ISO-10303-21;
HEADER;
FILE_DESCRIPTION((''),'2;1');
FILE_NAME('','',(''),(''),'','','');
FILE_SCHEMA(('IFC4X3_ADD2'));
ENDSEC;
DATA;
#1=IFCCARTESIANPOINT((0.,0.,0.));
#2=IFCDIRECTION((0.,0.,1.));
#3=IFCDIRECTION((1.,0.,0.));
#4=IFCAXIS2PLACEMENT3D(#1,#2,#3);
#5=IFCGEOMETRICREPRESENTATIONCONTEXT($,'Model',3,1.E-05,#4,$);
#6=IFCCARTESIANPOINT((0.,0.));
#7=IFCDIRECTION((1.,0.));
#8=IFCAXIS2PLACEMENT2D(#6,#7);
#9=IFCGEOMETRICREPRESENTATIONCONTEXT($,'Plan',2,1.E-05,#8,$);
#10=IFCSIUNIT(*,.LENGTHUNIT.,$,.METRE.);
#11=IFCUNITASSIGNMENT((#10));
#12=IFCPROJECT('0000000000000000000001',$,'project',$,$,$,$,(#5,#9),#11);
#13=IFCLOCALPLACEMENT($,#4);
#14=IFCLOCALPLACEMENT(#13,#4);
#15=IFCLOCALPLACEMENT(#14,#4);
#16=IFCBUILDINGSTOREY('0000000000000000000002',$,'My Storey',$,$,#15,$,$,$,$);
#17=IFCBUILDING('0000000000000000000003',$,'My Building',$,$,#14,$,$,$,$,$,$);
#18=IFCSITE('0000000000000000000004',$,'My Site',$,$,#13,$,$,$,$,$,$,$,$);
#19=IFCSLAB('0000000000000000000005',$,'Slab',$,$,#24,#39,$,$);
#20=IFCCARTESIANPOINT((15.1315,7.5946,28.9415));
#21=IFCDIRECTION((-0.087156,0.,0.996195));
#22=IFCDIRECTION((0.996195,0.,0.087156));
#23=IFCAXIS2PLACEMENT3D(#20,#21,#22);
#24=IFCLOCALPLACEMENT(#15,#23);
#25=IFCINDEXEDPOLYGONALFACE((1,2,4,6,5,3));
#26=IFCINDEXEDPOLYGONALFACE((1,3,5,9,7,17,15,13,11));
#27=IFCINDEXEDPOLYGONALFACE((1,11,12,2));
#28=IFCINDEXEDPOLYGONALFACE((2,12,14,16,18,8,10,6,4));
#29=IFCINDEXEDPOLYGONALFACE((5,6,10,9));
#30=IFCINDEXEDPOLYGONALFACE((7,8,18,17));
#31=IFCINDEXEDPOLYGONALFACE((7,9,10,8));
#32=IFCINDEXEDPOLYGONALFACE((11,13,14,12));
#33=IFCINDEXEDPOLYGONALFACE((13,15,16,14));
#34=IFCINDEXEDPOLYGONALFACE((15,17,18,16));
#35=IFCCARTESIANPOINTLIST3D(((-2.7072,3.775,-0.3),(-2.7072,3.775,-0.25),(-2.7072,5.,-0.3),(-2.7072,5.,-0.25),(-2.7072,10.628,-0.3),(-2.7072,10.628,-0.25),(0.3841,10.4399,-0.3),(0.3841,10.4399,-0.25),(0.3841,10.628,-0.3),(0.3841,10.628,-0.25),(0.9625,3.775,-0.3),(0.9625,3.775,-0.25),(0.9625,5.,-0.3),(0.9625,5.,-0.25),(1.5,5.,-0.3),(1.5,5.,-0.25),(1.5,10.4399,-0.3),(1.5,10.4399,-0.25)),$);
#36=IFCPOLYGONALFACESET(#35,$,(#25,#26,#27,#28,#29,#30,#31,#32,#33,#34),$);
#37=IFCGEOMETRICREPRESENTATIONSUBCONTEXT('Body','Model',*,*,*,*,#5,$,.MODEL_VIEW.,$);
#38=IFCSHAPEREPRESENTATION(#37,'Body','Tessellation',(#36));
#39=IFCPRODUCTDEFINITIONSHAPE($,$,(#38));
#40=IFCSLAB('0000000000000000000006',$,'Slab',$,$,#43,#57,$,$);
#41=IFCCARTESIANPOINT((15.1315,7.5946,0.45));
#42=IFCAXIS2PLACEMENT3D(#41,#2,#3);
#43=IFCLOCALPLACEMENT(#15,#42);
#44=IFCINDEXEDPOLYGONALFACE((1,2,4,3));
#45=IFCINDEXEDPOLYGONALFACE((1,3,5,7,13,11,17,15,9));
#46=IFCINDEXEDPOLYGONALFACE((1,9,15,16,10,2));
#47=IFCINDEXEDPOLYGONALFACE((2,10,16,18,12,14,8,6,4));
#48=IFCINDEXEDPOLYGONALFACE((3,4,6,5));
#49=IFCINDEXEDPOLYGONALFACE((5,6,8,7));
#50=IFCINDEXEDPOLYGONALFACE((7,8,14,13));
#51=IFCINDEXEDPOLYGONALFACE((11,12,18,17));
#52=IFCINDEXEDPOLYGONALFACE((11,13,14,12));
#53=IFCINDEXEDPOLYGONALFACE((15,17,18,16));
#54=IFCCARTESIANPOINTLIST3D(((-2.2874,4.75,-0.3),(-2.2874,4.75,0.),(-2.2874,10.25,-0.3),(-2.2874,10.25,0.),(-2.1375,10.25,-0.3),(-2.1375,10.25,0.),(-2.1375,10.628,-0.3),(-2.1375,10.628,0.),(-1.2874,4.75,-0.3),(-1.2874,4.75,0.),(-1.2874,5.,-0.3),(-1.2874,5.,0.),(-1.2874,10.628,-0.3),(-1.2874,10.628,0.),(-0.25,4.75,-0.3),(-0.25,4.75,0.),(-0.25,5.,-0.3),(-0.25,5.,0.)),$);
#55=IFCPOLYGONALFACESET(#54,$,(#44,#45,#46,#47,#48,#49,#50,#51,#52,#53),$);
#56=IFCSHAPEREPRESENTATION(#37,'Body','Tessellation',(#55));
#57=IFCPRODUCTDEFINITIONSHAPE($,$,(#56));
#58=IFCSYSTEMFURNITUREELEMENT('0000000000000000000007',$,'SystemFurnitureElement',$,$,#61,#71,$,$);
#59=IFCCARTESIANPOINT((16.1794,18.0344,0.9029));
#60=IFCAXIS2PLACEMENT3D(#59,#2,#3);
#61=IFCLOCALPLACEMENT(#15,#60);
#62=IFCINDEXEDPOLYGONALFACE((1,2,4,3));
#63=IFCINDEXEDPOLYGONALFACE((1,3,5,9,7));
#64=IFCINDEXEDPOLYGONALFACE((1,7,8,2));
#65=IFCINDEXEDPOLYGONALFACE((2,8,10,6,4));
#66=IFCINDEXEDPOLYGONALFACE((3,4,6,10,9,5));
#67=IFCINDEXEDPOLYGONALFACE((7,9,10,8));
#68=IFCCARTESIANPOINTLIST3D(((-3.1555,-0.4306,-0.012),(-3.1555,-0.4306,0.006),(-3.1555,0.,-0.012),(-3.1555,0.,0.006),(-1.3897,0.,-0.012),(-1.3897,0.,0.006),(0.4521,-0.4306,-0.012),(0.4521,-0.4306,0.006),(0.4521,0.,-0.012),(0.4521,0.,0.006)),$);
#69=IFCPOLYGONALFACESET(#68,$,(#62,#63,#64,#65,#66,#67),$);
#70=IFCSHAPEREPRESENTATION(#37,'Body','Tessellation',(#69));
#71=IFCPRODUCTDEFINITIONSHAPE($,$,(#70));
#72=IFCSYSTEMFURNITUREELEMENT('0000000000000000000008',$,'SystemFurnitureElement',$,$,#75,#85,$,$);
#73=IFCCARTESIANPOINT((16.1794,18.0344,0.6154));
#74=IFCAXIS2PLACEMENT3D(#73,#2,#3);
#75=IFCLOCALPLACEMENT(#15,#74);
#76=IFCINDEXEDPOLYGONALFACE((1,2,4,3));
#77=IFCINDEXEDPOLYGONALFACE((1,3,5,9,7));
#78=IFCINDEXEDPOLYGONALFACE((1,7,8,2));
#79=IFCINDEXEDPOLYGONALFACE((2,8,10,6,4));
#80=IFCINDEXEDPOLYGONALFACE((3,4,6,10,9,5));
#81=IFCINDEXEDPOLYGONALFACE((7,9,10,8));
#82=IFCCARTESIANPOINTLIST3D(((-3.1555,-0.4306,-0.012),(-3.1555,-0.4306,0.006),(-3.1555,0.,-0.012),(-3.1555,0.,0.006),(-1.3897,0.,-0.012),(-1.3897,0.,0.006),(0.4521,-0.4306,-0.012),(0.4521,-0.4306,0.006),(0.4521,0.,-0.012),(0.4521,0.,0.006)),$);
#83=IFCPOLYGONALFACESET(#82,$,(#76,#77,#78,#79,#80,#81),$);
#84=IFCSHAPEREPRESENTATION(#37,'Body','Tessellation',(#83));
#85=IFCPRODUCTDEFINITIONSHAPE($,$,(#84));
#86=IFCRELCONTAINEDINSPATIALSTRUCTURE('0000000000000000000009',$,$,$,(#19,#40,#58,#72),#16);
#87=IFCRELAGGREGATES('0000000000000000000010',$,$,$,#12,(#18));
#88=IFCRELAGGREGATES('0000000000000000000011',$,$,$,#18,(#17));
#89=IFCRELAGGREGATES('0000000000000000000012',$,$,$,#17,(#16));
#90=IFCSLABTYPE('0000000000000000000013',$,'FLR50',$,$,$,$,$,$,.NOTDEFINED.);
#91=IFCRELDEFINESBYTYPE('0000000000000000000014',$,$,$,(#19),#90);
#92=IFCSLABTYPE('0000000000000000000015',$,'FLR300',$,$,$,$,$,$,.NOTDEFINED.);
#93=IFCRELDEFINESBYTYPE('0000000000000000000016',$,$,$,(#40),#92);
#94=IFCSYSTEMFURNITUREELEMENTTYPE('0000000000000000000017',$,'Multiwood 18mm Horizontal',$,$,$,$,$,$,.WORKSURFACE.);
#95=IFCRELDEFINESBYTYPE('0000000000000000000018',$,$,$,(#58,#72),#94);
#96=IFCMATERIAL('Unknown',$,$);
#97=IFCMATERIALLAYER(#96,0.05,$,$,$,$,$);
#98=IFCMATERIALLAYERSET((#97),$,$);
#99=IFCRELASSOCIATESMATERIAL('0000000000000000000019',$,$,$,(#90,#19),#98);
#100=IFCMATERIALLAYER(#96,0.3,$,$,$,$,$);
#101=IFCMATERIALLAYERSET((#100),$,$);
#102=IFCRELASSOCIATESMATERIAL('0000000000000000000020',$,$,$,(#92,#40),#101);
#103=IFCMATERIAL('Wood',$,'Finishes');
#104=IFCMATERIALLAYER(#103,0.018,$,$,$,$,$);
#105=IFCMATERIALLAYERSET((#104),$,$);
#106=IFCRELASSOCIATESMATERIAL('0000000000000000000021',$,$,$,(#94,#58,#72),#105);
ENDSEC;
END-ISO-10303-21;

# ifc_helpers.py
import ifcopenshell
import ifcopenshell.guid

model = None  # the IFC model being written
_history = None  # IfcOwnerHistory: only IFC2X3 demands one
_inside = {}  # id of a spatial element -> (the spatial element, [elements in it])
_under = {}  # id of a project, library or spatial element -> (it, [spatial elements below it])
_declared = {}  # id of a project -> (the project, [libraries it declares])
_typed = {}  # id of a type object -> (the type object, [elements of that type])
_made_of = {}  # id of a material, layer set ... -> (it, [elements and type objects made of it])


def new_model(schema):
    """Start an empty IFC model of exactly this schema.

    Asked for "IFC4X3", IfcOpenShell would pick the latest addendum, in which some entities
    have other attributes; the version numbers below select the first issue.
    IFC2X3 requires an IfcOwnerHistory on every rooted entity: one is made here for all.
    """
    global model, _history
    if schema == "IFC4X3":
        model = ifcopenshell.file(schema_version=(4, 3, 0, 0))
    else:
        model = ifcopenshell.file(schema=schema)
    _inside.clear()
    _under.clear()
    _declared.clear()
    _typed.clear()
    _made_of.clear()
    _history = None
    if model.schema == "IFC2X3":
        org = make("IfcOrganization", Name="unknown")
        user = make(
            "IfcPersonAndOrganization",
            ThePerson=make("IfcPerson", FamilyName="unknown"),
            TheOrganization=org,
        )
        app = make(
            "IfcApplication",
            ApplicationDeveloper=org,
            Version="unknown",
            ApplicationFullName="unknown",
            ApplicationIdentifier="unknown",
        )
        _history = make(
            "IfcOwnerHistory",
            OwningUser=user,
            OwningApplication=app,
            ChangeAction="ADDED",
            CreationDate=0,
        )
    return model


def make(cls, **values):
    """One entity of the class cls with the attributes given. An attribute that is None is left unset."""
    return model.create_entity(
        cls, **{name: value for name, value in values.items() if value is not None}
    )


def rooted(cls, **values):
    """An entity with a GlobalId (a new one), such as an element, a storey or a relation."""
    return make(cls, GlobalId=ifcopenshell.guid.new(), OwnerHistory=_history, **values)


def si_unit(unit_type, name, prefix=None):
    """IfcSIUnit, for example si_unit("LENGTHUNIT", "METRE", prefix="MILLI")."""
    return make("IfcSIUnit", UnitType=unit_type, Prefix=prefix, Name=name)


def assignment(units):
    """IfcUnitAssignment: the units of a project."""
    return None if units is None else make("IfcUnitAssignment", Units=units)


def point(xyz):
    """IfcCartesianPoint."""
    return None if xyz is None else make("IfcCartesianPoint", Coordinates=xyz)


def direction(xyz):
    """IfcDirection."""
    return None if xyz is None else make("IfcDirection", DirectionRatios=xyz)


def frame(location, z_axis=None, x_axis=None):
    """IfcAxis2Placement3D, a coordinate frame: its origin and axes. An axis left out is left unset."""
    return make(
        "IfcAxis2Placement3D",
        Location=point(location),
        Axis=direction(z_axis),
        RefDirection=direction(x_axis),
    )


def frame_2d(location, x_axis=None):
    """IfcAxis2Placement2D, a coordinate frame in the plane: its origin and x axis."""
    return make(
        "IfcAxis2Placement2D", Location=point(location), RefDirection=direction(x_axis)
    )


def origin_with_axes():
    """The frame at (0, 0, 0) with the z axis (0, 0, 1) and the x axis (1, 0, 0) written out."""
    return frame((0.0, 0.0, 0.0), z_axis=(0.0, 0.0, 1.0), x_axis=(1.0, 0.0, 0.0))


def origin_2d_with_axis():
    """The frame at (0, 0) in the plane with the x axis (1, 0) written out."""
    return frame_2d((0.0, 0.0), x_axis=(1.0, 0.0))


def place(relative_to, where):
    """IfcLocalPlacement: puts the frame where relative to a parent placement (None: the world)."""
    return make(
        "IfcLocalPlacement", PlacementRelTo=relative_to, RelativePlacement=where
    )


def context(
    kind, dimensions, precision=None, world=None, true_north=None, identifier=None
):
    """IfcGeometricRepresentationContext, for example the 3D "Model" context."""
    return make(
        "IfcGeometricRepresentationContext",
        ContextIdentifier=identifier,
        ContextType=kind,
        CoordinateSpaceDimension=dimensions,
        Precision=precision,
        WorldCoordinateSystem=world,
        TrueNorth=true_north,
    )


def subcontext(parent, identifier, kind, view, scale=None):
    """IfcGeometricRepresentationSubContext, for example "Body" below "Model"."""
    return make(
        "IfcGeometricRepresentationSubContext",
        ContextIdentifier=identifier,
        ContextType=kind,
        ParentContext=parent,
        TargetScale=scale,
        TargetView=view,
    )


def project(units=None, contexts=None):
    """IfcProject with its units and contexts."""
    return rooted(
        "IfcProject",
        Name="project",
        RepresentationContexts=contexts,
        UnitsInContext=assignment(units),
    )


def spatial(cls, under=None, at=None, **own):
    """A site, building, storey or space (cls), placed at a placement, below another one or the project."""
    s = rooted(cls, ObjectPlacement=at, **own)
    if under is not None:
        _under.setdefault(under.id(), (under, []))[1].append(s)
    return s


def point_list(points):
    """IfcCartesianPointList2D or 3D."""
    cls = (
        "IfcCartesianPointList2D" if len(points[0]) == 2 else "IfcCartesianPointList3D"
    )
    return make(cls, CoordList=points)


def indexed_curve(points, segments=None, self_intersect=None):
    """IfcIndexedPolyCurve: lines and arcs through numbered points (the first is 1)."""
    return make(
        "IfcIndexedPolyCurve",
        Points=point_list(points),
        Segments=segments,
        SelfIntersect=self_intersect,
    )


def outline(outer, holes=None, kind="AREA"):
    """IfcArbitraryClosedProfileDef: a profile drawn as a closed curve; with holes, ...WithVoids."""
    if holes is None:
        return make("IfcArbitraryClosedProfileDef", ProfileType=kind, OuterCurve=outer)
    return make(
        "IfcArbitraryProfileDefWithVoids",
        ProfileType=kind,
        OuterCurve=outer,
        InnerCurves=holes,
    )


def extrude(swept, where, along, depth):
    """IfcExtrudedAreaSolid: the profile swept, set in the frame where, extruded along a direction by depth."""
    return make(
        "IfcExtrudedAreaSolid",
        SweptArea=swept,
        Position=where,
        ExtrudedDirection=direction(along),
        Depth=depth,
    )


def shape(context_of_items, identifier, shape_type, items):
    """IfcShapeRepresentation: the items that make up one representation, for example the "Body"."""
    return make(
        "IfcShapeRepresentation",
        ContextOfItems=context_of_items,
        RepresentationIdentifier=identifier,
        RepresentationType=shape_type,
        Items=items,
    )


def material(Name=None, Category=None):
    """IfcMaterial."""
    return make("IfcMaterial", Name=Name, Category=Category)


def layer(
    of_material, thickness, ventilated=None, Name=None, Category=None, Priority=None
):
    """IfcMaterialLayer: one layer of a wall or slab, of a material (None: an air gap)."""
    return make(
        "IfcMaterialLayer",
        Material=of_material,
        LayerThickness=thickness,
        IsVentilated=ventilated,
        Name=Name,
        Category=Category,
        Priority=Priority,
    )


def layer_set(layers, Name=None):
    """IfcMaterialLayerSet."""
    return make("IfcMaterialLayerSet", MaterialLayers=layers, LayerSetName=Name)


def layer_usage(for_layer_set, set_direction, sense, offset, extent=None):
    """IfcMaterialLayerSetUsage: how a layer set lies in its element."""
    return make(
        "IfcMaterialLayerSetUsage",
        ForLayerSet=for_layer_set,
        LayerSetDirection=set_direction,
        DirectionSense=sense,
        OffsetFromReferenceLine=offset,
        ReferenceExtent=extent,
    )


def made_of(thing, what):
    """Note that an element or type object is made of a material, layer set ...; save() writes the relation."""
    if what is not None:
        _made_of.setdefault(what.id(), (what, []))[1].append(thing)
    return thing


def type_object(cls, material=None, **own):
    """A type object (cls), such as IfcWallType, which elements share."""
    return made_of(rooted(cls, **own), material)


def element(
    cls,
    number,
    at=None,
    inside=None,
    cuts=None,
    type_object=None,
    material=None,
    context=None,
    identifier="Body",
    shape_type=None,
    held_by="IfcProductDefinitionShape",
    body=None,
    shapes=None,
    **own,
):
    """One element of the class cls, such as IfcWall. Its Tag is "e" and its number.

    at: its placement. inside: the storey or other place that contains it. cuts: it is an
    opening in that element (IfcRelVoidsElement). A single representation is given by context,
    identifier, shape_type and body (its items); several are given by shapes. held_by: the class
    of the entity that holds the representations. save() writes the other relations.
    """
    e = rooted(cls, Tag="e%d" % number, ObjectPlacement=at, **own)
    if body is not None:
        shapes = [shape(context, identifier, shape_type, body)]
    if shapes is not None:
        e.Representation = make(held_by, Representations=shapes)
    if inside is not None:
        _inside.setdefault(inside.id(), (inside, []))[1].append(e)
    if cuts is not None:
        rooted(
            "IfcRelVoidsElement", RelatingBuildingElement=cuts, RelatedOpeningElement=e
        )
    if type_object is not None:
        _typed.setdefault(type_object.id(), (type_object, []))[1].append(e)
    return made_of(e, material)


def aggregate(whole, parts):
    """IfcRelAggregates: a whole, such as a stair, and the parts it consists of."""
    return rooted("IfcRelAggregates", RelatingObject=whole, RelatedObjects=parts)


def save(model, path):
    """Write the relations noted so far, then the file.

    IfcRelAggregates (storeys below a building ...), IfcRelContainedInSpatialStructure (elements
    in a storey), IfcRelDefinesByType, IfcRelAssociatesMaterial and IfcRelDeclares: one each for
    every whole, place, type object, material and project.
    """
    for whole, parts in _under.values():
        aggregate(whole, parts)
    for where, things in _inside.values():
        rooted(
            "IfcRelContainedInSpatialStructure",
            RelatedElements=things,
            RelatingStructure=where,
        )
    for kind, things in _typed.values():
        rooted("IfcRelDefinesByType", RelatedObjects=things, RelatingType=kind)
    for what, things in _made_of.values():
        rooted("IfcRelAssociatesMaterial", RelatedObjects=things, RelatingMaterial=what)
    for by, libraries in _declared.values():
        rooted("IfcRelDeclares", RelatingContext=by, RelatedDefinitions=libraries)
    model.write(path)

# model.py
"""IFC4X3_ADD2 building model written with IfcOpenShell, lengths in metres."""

from ifc_helpers import new_model, si_unit, frame, origin_with_axes, origin_2d_with_axis, place, context, subcontext, project, spatial, indexed_curve, outline, extrude, material, layer, layer_set, layer_usage, type_object, element, save


model = new_model("IFC4X3_ADD2")

# Units and contexts
model_context = context("Model", 3, precision=1e-05, world=origin_with_axes())
plan_context = context("Plan", 2, precision=1e-05, world=origin_2d_with_axis())
body_context = subcontext(model_context, "Body", "Model", "MODEL_VIEW")
ifc_project = project(units=[si_unit("LENGTHUNIT", "METRE")], contexts=[model_context, plan_context])

# Site, building, storey
site_placement = place(None, origin_with_axes())
site = spatial("IfcSite", under=ifc_project, at=site_placement, Name="My Site")
building_placement = place(site_placement, origin_with_axes())
building = spatial("IfcBuilding", under=site, at=building_placement, Name="My Building")
storey_placement = place(building_placement, origin_with_axes())
storey = spatial("IfcBuildingStorey", under=building, at=storey_placement, Name="My Storey")

# Slabs
ifc_material_1 = material(Name="Unknown")
ifc_layer_1 = layer(ifc_material_1, 0.05)
ifc_layer_set_1 = layer_set([ifc_layer_1])
ifc_layer_usage_1 = layer_usage(ifc_layer_set_1, "AXIS3", "POSITIVE", -0.3)
slab_type_1 = type_object("IfcSlabType", Name="FLR50", PredefinedType="NOTDEFINED", material=ifc_layer_set_1)
slab_1_placement = place(storey_placement, frame((15.1315, 7.5946, 28.9415), z_axis=(-0.087156, 0.0, 0.996195), x_axis=(0.996195, 0.0, 0.087156)))
element("IfcSlab", 1, at=slab_1_placement, inside=storey, type_object=slab_type_1, material=ifc_layer_usage_1, Name="Slab", context=body_context, shape_type="SweptSolid", body=[
    extrude(outline(indexed_curve([(0.3841, 10.4399), (0.3841, 10.628), (-2.7072, 10.628), (-2.7072, 5.0), (-2.7072, 3.775), (0.9625, 3.775), (0.9625, 5.0), (1.5, 5.0), (1.5, 10.4399), (0.3841, 10.4399)])), frame((0.0, 0.0, -0.3), z_axis=(0.0, 0.0, 1.0), x_axis=(1.0, 0.0, 0.0)), (0.0, 0.0, 1.0), 0.05),
])
ifc_layer_2 = layer(ifc_material_1, 0.3)
ifc_layer_set_2 = layer_set([ifc_layer_2])
ifc_layer_usage_2 = layer_usage(ifc_layer_set_2, "AXIS3", "POSITIVE", -0.3)
slab_type_2 = type_object("IfcSlabType", Name="FLR300", PredefinedType="NOTDEFINED", material=ifc_layer_set_2)
slab_2_placement = place(storey_placement, frame((15.1315, 7.5946, 0.45), z_axis=(0.0, 0.0, 1.0), x_axis=(1.0, 0.0, 0.0)))
element("IfcSlab", 2, at=slab_2_placement, inside=storey, type_object=slab_type_2, material=ifc_layer_usage_2, Name="Slab", context=body_context, shape_type="SweptSolid", body=[
    extrude(outline(indexed_curve([(-2.1375, 10.25), (-2.2874, 10.25), (-2.2874, 4.75), (-1.2874, 4.75), (-0.25, 4.75), (-0.25, 5.0), (-1.2874, 5.0), (-1.2874, 10.628), (-2.1375, 10.628), (-2.1375, 10.25)])), frame((0.0, 0.0, -0.3), z_axis=(0.0, 0.0, 1.0), x_axis=(1.0, 0.0, 0.0)), (0.0, 0.0, 1.0), 0.3),
])

# System furniture elements
ifc_material_2 = material(Name="Wood", Category="Finishes")
ifc_layer_3 = layer(ifc_material_2, 0.018)
ifc_layer_set_3 = layer_set([ifc_layer_3])
ifc_layer_usage_3 = layer_usage(ifc_layer_set_3, "AXIS3", "POSITIVE", -0.012)
system_furniture_element_type_1 = type_object("IfcSystemFurnitureElementType", Name="Multiwood 18mm Horizontal", PredefinedType="WORKSURFACE", material=ifc_layer_set_3)
system_furniture_element_1_placement = place(storey_placement, frame((16.1794, 18.0344, 0.9029), z_axis=(0.0, 0.0, 1.0), x_axis=(1.0, 0.0, 0.0)))
element("IfcSystemFurnitureElement", 3, at=system_furniture_element_1_placement, inside=storey, type_object=system_furniture_element_type_1, material=ifc_layer_usage_3, Name="SystemFurnitureElement", context=body_context, shape_type="SweptSolid", body=[
    extrude(outline(indexed_curve([(-3.1555, -0.4306), (-3.1555, 0.0), (-1.3897, 0.0), (0.4521, 0.0), (0.4521, -0.4306), (-3.1555, -0.4306)])), frame((0.0, 0.0, -0.012), z_axis=(0.0, 0.0, 1.0), x_axis=(1.0, 0.0, 0.0)), (0.0, 0.0, 1.0), 0.018),
])
ifc_layer_usage_4 = layer_usage(ifc_layer_set_3, "AXIS3", "POSITIVE", -0.012)
system_furniture_element_2_placement = place(storey_placement, frame((16.1794, 18.0344, 0.6154), z_axis=(0.0, 0.0, 1.0), x_axis=(1.0, 0.0, 0.0)))
element("IfcSystemFurnitureElement", 4, at=system_furniture_element_2_placement, inside=storey, type_object=system_furniture_element_type_1, material=ifc_layer_usage_4, Name="SystemFurnitureElement", context=body_context, shape_type="SweptSolid", body=[
    extrude(outline(indexed_curve([(-3.1555, -0.4306), (-3.1555, 0.0), (-1.3897, 0.0), (0.4521, 0.0), (0.4521, -0.4306), (-3.1555, -0.4306)])), frame((0.0, 0.0, -0.012), z_axis=(0.0, 0.0, 1.0), x_axis=(1.0, 0.0, 0.0)), (0.0, 0.0, 1.0), 0.018),
])

save(model, "model.ifc")
